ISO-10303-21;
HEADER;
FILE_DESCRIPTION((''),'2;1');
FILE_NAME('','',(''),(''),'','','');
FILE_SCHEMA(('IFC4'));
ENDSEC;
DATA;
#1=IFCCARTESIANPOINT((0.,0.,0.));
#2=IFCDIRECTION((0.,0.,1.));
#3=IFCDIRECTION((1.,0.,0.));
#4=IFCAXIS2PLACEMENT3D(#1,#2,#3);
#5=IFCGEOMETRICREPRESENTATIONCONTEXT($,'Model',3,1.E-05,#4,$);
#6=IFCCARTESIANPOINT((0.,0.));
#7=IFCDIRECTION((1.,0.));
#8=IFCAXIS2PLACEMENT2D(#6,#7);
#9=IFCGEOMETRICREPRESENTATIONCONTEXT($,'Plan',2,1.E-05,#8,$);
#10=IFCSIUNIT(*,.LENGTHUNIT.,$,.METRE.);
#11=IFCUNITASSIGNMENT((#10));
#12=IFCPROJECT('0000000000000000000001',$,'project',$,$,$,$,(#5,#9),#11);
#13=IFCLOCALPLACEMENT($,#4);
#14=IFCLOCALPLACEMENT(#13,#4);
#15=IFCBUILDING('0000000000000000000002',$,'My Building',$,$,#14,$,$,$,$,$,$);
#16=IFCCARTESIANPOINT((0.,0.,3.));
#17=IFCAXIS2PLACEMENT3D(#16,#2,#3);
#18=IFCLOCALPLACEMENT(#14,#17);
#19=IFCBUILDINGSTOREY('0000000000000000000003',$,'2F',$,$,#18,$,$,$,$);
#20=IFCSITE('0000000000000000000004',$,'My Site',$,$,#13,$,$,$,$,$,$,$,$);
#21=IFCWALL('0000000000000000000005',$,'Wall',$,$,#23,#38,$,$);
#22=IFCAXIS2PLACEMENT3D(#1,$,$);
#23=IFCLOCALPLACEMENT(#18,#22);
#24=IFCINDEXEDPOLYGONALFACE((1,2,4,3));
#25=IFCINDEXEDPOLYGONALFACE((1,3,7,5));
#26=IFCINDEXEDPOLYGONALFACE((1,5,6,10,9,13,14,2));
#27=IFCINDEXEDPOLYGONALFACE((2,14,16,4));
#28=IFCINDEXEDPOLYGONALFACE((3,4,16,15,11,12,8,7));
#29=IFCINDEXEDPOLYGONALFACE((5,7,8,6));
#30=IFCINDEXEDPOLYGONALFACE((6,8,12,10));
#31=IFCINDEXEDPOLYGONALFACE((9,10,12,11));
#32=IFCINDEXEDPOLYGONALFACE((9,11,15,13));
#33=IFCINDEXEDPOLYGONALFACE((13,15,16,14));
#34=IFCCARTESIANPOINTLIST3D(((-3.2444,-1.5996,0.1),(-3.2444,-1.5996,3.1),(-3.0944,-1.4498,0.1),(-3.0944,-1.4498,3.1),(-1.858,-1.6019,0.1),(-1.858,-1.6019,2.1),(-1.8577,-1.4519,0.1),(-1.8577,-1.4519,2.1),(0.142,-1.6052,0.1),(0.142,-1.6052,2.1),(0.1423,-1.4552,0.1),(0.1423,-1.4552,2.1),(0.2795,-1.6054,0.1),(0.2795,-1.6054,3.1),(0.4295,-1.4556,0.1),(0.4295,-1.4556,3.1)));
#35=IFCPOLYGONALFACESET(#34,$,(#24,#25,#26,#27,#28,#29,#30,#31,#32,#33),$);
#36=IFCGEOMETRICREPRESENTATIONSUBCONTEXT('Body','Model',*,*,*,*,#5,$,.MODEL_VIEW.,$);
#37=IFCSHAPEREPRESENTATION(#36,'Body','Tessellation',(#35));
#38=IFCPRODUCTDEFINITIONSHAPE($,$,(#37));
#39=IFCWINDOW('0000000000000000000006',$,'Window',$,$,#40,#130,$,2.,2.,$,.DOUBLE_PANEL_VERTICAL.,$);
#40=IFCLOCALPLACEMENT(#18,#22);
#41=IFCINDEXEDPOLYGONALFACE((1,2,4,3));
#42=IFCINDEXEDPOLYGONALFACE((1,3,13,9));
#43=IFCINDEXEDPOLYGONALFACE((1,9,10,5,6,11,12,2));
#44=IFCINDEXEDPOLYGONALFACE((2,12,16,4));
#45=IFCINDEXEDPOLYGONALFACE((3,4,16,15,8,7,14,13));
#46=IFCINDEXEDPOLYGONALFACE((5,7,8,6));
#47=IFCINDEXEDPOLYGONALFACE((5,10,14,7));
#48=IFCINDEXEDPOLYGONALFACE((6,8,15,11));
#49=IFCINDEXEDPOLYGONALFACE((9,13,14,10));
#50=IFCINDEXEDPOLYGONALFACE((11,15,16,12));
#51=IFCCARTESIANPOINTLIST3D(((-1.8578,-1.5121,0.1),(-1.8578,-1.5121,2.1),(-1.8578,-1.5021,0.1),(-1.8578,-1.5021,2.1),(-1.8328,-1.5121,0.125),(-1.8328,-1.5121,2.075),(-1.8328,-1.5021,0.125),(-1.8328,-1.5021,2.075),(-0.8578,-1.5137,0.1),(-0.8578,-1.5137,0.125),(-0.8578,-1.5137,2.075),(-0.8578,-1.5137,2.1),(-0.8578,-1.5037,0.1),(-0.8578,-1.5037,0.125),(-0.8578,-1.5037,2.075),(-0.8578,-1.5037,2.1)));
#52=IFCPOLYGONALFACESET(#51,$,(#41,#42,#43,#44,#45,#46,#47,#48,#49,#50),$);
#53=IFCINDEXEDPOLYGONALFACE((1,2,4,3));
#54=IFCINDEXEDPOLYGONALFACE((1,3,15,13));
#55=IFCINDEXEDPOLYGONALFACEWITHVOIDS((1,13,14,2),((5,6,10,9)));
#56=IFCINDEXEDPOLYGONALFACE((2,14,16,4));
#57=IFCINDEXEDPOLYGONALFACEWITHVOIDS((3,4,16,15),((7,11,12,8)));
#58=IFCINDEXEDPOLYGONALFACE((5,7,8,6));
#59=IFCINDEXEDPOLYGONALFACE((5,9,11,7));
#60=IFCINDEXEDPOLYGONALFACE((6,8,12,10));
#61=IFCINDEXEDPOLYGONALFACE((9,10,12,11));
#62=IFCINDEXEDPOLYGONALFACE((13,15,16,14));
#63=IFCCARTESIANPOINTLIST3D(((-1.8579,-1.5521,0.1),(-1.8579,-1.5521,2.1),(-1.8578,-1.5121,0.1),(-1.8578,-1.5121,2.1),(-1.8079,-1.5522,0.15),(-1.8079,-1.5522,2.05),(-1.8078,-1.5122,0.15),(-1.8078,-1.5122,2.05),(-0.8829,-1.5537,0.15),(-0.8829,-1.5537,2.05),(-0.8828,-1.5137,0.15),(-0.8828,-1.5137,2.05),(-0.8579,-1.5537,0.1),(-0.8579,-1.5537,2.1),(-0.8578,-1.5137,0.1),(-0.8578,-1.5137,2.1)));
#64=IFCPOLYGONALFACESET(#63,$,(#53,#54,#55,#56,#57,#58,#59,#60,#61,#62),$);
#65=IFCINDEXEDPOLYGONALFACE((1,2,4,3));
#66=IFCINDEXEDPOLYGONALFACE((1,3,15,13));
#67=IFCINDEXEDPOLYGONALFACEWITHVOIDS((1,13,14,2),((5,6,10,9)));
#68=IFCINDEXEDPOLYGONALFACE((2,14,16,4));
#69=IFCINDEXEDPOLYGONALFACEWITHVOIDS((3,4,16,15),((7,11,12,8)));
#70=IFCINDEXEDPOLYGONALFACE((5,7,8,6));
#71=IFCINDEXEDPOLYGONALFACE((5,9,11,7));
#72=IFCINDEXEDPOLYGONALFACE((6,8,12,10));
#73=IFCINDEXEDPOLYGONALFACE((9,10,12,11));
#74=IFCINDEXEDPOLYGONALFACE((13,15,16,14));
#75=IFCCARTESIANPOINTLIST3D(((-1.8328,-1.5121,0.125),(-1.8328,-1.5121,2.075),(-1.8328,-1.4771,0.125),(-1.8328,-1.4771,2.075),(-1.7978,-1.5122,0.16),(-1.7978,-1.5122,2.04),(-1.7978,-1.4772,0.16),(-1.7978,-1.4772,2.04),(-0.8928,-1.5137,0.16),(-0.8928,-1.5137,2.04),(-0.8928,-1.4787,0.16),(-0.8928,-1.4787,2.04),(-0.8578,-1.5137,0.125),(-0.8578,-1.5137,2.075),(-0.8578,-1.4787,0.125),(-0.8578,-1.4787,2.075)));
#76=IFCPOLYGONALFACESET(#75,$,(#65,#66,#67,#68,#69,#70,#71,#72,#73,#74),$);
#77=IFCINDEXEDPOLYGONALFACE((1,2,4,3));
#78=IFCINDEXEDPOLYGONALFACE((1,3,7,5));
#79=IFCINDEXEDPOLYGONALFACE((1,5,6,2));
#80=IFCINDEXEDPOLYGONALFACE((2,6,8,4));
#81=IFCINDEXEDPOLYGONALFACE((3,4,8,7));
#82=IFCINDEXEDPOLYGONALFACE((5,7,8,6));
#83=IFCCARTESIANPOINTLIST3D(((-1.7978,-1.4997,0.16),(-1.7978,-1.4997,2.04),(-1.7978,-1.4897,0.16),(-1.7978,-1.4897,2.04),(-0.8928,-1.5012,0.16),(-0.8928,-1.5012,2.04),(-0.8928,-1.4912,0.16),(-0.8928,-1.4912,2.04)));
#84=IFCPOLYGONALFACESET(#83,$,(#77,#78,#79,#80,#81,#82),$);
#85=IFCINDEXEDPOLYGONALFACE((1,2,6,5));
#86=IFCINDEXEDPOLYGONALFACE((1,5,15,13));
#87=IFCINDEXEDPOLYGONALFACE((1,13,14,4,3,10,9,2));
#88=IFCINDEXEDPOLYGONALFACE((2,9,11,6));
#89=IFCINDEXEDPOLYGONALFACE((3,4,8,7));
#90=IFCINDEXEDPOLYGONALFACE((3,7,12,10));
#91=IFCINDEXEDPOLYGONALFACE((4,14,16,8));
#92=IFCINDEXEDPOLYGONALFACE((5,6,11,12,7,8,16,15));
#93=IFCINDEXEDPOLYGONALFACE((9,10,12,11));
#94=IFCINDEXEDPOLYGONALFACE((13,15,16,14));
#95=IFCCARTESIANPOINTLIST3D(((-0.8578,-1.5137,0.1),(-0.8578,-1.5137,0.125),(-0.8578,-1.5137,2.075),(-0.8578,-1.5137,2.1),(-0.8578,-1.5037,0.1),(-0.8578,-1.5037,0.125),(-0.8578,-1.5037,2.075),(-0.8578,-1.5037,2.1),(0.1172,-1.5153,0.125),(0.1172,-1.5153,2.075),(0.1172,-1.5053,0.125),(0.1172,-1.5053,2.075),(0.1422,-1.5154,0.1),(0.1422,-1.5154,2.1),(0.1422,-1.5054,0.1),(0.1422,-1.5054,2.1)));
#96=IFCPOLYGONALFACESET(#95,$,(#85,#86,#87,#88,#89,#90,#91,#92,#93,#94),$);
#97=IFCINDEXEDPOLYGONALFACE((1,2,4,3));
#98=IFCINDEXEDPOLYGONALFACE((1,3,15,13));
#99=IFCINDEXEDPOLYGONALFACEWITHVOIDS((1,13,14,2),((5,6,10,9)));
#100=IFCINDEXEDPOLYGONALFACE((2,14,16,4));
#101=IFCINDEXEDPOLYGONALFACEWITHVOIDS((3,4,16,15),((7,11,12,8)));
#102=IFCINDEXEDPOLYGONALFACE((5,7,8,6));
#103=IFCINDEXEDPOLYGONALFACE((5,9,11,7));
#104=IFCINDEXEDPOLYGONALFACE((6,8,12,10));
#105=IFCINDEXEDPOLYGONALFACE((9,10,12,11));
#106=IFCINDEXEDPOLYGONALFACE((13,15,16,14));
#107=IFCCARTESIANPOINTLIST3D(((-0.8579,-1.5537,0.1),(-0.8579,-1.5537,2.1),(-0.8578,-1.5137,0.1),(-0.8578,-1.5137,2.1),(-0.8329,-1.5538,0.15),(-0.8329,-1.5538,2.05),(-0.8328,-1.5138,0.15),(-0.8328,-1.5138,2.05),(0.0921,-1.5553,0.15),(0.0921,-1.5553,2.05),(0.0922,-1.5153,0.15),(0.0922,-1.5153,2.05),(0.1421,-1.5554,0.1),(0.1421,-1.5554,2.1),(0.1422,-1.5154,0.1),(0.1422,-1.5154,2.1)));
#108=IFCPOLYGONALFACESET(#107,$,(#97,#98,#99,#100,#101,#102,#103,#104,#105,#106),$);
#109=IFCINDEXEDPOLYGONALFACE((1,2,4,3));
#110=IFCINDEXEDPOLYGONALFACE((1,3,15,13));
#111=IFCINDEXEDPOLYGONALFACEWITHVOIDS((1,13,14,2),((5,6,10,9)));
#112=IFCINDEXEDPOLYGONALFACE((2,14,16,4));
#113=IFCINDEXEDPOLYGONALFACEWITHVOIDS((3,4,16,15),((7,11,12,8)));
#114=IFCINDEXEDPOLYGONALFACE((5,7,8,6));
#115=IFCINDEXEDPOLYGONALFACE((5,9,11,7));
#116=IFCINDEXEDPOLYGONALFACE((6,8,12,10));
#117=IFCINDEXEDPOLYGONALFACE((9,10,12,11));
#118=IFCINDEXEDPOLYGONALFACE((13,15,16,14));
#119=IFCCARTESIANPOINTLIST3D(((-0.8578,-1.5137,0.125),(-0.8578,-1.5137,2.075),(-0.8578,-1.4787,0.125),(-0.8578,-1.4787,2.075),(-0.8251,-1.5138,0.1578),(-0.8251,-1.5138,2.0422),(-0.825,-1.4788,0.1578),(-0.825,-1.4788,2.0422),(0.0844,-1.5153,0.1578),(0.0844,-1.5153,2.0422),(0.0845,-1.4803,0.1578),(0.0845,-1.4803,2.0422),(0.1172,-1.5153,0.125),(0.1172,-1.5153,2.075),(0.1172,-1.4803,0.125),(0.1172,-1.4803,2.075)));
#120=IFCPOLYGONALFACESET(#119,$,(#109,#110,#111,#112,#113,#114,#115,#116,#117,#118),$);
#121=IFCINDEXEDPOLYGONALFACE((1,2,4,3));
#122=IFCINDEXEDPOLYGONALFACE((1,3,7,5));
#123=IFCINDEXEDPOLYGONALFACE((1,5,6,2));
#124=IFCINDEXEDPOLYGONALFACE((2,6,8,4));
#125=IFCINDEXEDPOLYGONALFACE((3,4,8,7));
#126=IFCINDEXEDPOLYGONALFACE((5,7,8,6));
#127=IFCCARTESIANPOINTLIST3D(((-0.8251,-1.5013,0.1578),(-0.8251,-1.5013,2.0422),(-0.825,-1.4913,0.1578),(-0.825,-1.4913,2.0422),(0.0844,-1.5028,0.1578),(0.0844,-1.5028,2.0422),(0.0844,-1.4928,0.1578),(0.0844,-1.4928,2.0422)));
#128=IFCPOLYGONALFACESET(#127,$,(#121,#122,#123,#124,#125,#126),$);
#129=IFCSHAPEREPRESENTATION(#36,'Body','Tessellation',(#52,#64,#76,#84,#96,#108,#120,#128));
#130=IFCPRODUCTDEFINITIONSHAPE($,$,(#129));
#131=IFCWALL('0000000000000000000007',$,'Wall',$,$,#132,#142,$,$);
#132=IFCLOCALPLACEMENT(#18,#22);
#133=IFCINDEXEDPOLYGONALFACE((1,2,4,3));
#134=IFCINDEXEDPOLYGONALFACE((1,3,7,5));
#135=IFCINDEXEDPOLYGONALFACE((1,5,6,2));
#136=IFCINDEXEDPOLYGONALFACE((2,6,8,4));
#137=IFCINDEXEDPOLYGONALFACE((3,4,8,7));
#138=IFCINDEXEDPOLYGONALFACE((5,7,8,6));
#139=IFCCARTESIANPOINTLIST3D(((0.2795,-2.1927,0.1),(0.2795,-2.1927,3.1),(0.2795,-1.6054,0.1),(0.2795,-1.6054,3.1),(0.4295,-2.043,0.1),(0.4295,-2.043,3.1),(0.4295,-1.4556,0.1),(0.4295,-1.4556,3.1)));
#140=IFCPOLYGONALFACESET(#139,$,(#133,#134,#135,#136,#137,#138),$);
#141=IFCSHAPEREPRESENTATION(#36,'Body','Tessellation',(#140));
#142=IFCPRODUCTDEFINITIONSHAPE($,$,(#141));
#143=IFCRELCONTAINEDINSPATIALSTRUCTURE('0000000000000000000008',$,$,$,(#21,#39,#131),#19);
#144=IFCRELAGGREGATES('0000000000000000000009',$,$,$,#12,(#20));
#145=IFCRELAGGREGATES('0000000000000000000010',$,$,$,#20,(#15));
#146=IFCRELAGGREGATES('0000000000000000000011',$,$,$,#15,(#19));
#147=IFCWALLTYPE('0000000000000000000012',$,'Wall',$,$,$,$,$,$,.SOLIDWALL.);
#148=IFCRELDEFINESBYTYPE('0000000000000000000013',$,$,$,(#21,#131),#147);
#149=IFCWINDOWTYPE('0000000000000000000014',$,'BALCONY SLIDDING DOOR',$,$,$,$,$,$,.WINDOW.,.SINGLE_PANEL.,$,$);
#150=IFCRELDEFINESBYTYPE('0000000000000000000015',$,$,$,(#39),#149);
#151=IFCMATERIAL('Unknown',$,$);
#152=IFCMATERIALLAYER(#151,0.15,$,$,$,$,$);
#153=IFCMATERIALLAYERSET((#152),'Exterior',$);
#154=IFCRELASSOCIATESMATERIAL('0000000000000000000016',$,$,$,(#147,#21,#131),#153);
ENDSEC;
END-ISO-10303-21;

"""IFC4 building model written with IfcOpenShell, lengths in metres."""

from ifc_helpers import new_model, entity, si_unit, frame, origin_with_axes, origin_2d_with_axis, place, context, subcontext, project, spatial, line, indexed_curve, outline, extrude, shape, source, transform, mapped, material, layer, layer_set, layer_usage, type_object, type_shapes, element, fill, save


model = new_model("IFC4")

# Units and contexts
model_context = context("Model", 3, precision=1e-05, world=origin_with_axes())
plan_context = context("Plan", 2, precision=1e-05, world=origin_2d_with_axis())
body_context_1 = subcontext(model_context, "Body", "Model", "MODEL_VIEW")
body_context_2 = subcontext(plan_context, "Body", "Plan", "PLAN_VIEW")
ifc_project = project(units=[si_unit("LENGTHUNIT", "METRE")], contexts=[model_context, plan_context])

# Site, building, storey
site_placement = place(None, origin_with_axes())
site = spatial("IfcSite", under=ifc_project, at=site_placement, Name="My Site")
building_placement = place(site_placement, origin_with_axes())
building = spatial("IfcBuilding", under=site, at=building_placement, Name="My Building")
storey_placement = place(building_placement, frame((0.0, 0.0, 3.0), z_axis=(0.0, 0.0, 1.0), x_axis=(1.0, 0.0, 0.0)))
storey = spatial("IfcBuildingStorey", under=building, at=storey_placement, Name="2F")

# Shared definitions
ifc_material = material(Name="Unknown")

# Wall, opening, window
ifc_layer_1 = layer(ifc_material, 0.15)
ifc_layer_set_1 = layer_set([ifc_layer_1], Name="Exterior")
ifc_layer_usage_1 = layer_usage(ifc_layer_set_1, "AXIS2", "POSITIVE", 0.0)
wall_type_1 = type_object("IfcWallType", Name="Wall", PredefinedType="SOLIDWALL", material=ifc_layer_set_1)
wall_1_placement = place(storey_placement, frame((-3.2444, -1.5996, 0.1), z_axis=(0.0, 0.0, 1.0), x_axis=(0.999999, -0.00165, 0.0)))
wall_1 = element("IfcWall", 1, at=wall_1_placement, inside=storey, type_object=wall_type_1, material=ifc_layer_usage_1, Name="Wall", context=body_context_1, shape_type="SweptSolid", body=[
    extrude(outline(indexed_curve([(0.0, 0.0), (0.1498, 0.15), (3.6737, 0.15), (3.5239, 0.0)], segments=[line(1, 2, 3, 4, 1)])), origin_with_axes(), (0.0, 0.0, 1.0), 3.0),
])
shared_shape_1 = source(origin_with_axes(), body_context_1, "Body", "SweptSolid", [
    extrude(outline(indexed_curve([(0.0, 0.0), (2.0, 0.0), (2.0, 2.0), (0.0, 2.0)], segments=[line(1, 2, 3, 4, 1)])), frame((0.0, -0.6, 0.0), z_axis=(0.0, -1.0, 0.0), x_axis=(1.0, 0.0, 0.0)), (0.0, 0.0, -1.0), 1.2),
])
opening_1_placement = place(wall_1_placement, frame((1.3864, -0.0002, 0.0), z_axis=(0.0, 0.0, 1.0), x_axis=(1.0, 0.0, 0.0)))
opening_1 = element("IfcOpeningElement", 2, at=opening_1_placement, cuts=wall_1, PredefinedType="OPENING", context=body_context_1, shape_type="MappedRepresentation", body=[
    mapped(shared_shape_1, transform((0.0, 0.0, 0.0), x_axis=(1.0, 0.0, 0.0), y_axis=(0.0, 1.0, 0.0), z_axis=(0.0, 0.0, 1.0), scale=1.0)),
])
window_type_1 = type_object("IfcWindowType", Name="BALCONY SLIDDING DOOR", PartitioningType="SINGLE_PANEL", PredefinedType="WINDOW")
shared_shape_2 = source(origin_with_axes(), body_context_1, "Body", "SweptSolid", [
    extrude(outline(indexed_curve([(1.0, 0.0), (0.0, 0.0), (0.0, 2.0), (1.0, 2.0), (1.0, 1.975), (0.025, 1.975), (0.025, 0.025), (1.0, 0.025)], segments=[line(1, 2, 3, 4, 5, 6, 7, 8, 1)])), frame((0.0, 0.09, 0.0), z_axis=(0.0, -1.0, 0.0), x_axis=(1.0, 0.0, 0.0)), (0.0, 0.0, -1.0), 0.01),
    extrude(outline(indexed_curve([(0.0, 0.0), (1.0, 0.0), (1.0, 2.0), (0.0, 2.0)], segments=[line(1, 2, 3, 4, 1)]), holes=[indexed_curve([(0.05, 0.05), (0.975, 0.05), (0.975, 1.95), (0.05, 1.95)], segments=[line(1, 2, 3, 4, 1)])]), frame((0.0, 0.05, 0.0), z_axis=(0.0, -1.0, 0.0), x_axis=(1.0, 0.0, 0.0)), (0.0, 0.0, -1.0), 0.04),
    extrude(outline(indexed_curve([(0.0, 0.0), (0.975, 0.0), (0.975, 1.95), (0.0, 1.95)], segments=[line(1, 2, 3, 4, 1)]), holes=[indexed_curve([(0.035, 0.035), (0.94, 0.035), (0.94, 1.915), (0.035, 1.915)], segments=[line(1, 2, 3, 4, 1)])]), frame((0.025, 0.09, 0.025), z_axis=(0.0, -1.0, 0.0), x_axis=(1.0, 0.0, 0.0)), (0.0, 0.0, -1.0), 0.035),
    extrude(outline(indexed_curve([(0.035, 0.035), (0.94, 0.035), (0.94, 1.915), (0.035, 1.915)], segments=[line(1, 2, 3, 4, 1)])), frame((0.025, 0.1025, 0.025), z_axis=(0.0, -1.0, 0.0), x_axis=(1.0, 0.0, 0.0)), (0.0, 0.0, -1.0), 0.01),
    extrude(outline(indexed_curve([(0.0, 2.0), (1.0, 2.0), (1.0, 0.0), (0.0, 0.0), (0.0, 0.025), (0.975, 0.025), (0.975, 1.975), (0.0, 1.975)], segments=[line(1, 2, 3, 4, 5, 6, 7, 8, 1)])), frame((1.0, 0.09, 0.0), z_axis=(0.0, -1.0, 0.0), x_axis=(1.0, 0.0, 0.0)), (0.0, 0.0, -1.0), 0.01),
    extrude(outline(indexed_curve([(0.0, 0.0), (1.0, 0.0), (1.0, 2.0), (0.0, 2.0)], segments=[line(1, 2, 3, 4, 1)]), holes=[indexed_curve([(0.025, 0.05), (0.95, 0.05), (0.95, 1.95), (0.025, 1.95)], segments=[line(1, 2, 3, 4, 1)])]), frame((1.0, 0.05, 0.0), z_axis=(0.0, -1.0, 0.0), x_axis=(1.0, 0.0, 0.0)), (0.0, 0.0, -1.0), 0.04),
    extrude(outline(indexed_curve([(0.0, 0.0), (0.975, 0.0), (0.975, 1.95), (0.0, 1.95)], segments=[line(1, 2, 3, 4, 1)]), holes=[indexed_curve([(0.0328, 0.0328), (0.9422, 0.0328), (0.9422, 1.9172), (0.0328, 1.9172)], segments=[line(1, 2, 3, 4, 1)])]), frame((1.0, 0.09, 0.025), z_axis=(0.0, -1.0, 0.0), x_axis=(1.0, 0.0, 0.0)), (0.0, 0.0, -1.0), 0.035),
    extrude(outline(indexed_curve([(0.0328, 0.0328), (0.9422, 0.0328), (0.9422, 1.9172), (0.0328, 1.9172)], segments=[line(1, 2, 3, 4, 1)])), frame((1.0, 0.1025, 0.025), z_axis=(0.0, -1.0, 0.0), x_axis=(1.0, 0.0, 0.0)), (0.0, 0.0, -1.0), 0.01),
])
shared_shape_3 = source(origin_with_axes(), body_context_2, "Body", "Curve2D", [
    entity("IfcIndexedPolyCurve", entity("IfcCartesianPointList2D", [[0.05, 0.05], [0.975, 0.05]])),
    entity("IfcIndexedPolyCurve", entity("IfcCartesianPointList2D", [[0.0, 0.1], [0.025, 0.1], [0.025, 0.09], [0.05, 0.09], [0.05, 0.05], [0.0, 0.05]]), [entity("IfcLineIndex", [1, 2, 3, 4, 5, 6, 1])]),
    entity("IfcIndexedPolyCurve", entity("IfcCartesianPointList2D", [[1.0, 0.1], [1.0, 0.1], [1.0, 0.09], [0.975, 0.09], [0.975, 0.05], [1.0, 0.05]])),
    entity("IfcIndexedPolyCurve", entity("IfcCartesianPointList2D", [[0.025, 0.09], [0.06, 0.09], [0.06, 0.125], [0.025, 0.125]]), [entity("IfcLineIndex", [1, 2, 3, 4, 1])]),
    entity("IfcIndexedPolyCurve", entity("IfcCartesianPointList2D", [[1.0, 0.09], [0.965, 0.09], [0.965, 0.125], [1.0, 0.125]]), [entity("IfcLineIndex", [1, 2, 3, 4, 1])]),
    entity("IfcIndexedPolyCurve", entity("IfcCartesianPointList2D", [[0.06, 0.09], [0.965, 0.09]])),
    entity("IfcIndexedPolyCurve", entity("IfcCartesianPointList2D", [[0.06, 0.125], [0.965, 0.125]])),
    entity("IfcIndexedPolyCurve", entity("IfcCartesianPointList2D", [[0.06, 0.1075], [0.965, 0.1075]])),
    entity("IfcIndexedPolyCurve", entity("IfcCartesianPointList2D", [[1.025, 0.05], [1.95, 0.05]])),
    entity("IfcIndexedPolyCurve", entity("IfcCartesianPointList2D", [[1.0, 0.1], [1.0, 0.1], [1.0, 0.09], [1.025, 0.09], [1.025, 0.05], [1.0, 0.05]])),
    entity("IfcIndexedPolyCurve", entity("IfcCartesianPointList2D", [[2.0, 0.1], [1.975, 0.1], [1.975, 0.09], [1.95, 0.09], [1.95, 0.05], [2.0, 0.05]]), [entity("IfcLineIndex", [1, 2, 3, 4, 5, 6, 1])]),
    entity("IfcIndexedPolyCurve", entity("IfcCartesianPointList2D", [[1.0, 0.09], [1.0328, 0.09], [1.0328, 0.125], [1.0, 0.125]]), [entity("IfcLineIndex", [1, 2, 3, 4, 1])]),
    entity("IfcIndexedPolyCurve", entity("IfcCartesianPointList2D", [[1.975, 0.09], [1.9422, 0.09], [1.9422, 0.125], [1.975, 0.125]]), [entity("IfcLineIndex", [1, 2, 3, 4, 1])]),
    entity("IfcIndexedPolyCurve", entity("IfcCartesianPointList2D", [[1.0328, 0.09], [1.9422, 0.09]])),
    entity("IfcIndexedPolyCurve", entity("IfcCartesianPointList2D", [[1.0328, 0.125], [1.9422, 0.125]])),
    entity("IfcIndexedPolyCurve", entity("IfcCartesianPointList2D", [[1.0328, 0.1075], [1.9422, 0.1075]])),
])
type_shapes(window_type_1, [shared_shape_2, shared_shape_3])
window_1_placement = place(opening_1_placement, frame((0.0, 0.0, 0.0), z_axis=(0.0, 0.0, 1.0), x_axis=(1.0, 0.0, 0.0)))
window_1 = element("IfcWindow", 3, at=window_1_placement, inside=storey, type_object=window_type_1, Name="Window", OverallHeight=2.0, OverallWidth=2.0, PartitioningType="DOUBLE_PANEL_VERTICAL", shapes=[
    shape(body_context_1, "Body", "MappedRepresentation", [mapped(shared_shape_2, transform((0.0, 0.0, 0.0), x_axis=(1.0, 0.0, 0.0), y_axis=(0.0, 1.0, 0.0), z_axis=(0.0, 0.0, 1.0), scale=1.0))]),
    shape(body_context_2, "Body", "MappedRepresentation", [mapped(shared_shape_3, transform((0.0, 0.0, 0.0), x_axis=(1.0, 0.0, 0.0), y_axis=(0.0, 1.0, 0.0), z_axis=(0.0, 0.0, 1.0), scale=1.0))]),
])
fill(opening_1, window_1)

# Wall
ifc_layer_usage_2 = layer_usage(ifc_layer_set_1, "AXIS2", "POSITIVE", 0.0)
wall_2_placement = place(storey_placement, frame((0.2795, -1.6054, 0.1), z_axis=(0.0, 0.0, 1.0), x_axis=(0.0, -1.0, 0.0)))
element("IfcWall", 4, at=wall_2_placement, inside=storey, type_object=wall_type_1, material=ifc_layer_usage_2, Name="Wall", context=body_context_1, shape_type="SweptSolid", body=[
    extrude(outline(indexed_curve([(0.0, 0.0), (-0.1498, 0.15), (0.4377, 0.15), (0.5873, 0.0)], segments=[line(1, 2, 3, 4, 1)])), origin_with_axes(), (0.0, 0.0, 1.0), 3.0),
])

save(model, "model.ifc")
